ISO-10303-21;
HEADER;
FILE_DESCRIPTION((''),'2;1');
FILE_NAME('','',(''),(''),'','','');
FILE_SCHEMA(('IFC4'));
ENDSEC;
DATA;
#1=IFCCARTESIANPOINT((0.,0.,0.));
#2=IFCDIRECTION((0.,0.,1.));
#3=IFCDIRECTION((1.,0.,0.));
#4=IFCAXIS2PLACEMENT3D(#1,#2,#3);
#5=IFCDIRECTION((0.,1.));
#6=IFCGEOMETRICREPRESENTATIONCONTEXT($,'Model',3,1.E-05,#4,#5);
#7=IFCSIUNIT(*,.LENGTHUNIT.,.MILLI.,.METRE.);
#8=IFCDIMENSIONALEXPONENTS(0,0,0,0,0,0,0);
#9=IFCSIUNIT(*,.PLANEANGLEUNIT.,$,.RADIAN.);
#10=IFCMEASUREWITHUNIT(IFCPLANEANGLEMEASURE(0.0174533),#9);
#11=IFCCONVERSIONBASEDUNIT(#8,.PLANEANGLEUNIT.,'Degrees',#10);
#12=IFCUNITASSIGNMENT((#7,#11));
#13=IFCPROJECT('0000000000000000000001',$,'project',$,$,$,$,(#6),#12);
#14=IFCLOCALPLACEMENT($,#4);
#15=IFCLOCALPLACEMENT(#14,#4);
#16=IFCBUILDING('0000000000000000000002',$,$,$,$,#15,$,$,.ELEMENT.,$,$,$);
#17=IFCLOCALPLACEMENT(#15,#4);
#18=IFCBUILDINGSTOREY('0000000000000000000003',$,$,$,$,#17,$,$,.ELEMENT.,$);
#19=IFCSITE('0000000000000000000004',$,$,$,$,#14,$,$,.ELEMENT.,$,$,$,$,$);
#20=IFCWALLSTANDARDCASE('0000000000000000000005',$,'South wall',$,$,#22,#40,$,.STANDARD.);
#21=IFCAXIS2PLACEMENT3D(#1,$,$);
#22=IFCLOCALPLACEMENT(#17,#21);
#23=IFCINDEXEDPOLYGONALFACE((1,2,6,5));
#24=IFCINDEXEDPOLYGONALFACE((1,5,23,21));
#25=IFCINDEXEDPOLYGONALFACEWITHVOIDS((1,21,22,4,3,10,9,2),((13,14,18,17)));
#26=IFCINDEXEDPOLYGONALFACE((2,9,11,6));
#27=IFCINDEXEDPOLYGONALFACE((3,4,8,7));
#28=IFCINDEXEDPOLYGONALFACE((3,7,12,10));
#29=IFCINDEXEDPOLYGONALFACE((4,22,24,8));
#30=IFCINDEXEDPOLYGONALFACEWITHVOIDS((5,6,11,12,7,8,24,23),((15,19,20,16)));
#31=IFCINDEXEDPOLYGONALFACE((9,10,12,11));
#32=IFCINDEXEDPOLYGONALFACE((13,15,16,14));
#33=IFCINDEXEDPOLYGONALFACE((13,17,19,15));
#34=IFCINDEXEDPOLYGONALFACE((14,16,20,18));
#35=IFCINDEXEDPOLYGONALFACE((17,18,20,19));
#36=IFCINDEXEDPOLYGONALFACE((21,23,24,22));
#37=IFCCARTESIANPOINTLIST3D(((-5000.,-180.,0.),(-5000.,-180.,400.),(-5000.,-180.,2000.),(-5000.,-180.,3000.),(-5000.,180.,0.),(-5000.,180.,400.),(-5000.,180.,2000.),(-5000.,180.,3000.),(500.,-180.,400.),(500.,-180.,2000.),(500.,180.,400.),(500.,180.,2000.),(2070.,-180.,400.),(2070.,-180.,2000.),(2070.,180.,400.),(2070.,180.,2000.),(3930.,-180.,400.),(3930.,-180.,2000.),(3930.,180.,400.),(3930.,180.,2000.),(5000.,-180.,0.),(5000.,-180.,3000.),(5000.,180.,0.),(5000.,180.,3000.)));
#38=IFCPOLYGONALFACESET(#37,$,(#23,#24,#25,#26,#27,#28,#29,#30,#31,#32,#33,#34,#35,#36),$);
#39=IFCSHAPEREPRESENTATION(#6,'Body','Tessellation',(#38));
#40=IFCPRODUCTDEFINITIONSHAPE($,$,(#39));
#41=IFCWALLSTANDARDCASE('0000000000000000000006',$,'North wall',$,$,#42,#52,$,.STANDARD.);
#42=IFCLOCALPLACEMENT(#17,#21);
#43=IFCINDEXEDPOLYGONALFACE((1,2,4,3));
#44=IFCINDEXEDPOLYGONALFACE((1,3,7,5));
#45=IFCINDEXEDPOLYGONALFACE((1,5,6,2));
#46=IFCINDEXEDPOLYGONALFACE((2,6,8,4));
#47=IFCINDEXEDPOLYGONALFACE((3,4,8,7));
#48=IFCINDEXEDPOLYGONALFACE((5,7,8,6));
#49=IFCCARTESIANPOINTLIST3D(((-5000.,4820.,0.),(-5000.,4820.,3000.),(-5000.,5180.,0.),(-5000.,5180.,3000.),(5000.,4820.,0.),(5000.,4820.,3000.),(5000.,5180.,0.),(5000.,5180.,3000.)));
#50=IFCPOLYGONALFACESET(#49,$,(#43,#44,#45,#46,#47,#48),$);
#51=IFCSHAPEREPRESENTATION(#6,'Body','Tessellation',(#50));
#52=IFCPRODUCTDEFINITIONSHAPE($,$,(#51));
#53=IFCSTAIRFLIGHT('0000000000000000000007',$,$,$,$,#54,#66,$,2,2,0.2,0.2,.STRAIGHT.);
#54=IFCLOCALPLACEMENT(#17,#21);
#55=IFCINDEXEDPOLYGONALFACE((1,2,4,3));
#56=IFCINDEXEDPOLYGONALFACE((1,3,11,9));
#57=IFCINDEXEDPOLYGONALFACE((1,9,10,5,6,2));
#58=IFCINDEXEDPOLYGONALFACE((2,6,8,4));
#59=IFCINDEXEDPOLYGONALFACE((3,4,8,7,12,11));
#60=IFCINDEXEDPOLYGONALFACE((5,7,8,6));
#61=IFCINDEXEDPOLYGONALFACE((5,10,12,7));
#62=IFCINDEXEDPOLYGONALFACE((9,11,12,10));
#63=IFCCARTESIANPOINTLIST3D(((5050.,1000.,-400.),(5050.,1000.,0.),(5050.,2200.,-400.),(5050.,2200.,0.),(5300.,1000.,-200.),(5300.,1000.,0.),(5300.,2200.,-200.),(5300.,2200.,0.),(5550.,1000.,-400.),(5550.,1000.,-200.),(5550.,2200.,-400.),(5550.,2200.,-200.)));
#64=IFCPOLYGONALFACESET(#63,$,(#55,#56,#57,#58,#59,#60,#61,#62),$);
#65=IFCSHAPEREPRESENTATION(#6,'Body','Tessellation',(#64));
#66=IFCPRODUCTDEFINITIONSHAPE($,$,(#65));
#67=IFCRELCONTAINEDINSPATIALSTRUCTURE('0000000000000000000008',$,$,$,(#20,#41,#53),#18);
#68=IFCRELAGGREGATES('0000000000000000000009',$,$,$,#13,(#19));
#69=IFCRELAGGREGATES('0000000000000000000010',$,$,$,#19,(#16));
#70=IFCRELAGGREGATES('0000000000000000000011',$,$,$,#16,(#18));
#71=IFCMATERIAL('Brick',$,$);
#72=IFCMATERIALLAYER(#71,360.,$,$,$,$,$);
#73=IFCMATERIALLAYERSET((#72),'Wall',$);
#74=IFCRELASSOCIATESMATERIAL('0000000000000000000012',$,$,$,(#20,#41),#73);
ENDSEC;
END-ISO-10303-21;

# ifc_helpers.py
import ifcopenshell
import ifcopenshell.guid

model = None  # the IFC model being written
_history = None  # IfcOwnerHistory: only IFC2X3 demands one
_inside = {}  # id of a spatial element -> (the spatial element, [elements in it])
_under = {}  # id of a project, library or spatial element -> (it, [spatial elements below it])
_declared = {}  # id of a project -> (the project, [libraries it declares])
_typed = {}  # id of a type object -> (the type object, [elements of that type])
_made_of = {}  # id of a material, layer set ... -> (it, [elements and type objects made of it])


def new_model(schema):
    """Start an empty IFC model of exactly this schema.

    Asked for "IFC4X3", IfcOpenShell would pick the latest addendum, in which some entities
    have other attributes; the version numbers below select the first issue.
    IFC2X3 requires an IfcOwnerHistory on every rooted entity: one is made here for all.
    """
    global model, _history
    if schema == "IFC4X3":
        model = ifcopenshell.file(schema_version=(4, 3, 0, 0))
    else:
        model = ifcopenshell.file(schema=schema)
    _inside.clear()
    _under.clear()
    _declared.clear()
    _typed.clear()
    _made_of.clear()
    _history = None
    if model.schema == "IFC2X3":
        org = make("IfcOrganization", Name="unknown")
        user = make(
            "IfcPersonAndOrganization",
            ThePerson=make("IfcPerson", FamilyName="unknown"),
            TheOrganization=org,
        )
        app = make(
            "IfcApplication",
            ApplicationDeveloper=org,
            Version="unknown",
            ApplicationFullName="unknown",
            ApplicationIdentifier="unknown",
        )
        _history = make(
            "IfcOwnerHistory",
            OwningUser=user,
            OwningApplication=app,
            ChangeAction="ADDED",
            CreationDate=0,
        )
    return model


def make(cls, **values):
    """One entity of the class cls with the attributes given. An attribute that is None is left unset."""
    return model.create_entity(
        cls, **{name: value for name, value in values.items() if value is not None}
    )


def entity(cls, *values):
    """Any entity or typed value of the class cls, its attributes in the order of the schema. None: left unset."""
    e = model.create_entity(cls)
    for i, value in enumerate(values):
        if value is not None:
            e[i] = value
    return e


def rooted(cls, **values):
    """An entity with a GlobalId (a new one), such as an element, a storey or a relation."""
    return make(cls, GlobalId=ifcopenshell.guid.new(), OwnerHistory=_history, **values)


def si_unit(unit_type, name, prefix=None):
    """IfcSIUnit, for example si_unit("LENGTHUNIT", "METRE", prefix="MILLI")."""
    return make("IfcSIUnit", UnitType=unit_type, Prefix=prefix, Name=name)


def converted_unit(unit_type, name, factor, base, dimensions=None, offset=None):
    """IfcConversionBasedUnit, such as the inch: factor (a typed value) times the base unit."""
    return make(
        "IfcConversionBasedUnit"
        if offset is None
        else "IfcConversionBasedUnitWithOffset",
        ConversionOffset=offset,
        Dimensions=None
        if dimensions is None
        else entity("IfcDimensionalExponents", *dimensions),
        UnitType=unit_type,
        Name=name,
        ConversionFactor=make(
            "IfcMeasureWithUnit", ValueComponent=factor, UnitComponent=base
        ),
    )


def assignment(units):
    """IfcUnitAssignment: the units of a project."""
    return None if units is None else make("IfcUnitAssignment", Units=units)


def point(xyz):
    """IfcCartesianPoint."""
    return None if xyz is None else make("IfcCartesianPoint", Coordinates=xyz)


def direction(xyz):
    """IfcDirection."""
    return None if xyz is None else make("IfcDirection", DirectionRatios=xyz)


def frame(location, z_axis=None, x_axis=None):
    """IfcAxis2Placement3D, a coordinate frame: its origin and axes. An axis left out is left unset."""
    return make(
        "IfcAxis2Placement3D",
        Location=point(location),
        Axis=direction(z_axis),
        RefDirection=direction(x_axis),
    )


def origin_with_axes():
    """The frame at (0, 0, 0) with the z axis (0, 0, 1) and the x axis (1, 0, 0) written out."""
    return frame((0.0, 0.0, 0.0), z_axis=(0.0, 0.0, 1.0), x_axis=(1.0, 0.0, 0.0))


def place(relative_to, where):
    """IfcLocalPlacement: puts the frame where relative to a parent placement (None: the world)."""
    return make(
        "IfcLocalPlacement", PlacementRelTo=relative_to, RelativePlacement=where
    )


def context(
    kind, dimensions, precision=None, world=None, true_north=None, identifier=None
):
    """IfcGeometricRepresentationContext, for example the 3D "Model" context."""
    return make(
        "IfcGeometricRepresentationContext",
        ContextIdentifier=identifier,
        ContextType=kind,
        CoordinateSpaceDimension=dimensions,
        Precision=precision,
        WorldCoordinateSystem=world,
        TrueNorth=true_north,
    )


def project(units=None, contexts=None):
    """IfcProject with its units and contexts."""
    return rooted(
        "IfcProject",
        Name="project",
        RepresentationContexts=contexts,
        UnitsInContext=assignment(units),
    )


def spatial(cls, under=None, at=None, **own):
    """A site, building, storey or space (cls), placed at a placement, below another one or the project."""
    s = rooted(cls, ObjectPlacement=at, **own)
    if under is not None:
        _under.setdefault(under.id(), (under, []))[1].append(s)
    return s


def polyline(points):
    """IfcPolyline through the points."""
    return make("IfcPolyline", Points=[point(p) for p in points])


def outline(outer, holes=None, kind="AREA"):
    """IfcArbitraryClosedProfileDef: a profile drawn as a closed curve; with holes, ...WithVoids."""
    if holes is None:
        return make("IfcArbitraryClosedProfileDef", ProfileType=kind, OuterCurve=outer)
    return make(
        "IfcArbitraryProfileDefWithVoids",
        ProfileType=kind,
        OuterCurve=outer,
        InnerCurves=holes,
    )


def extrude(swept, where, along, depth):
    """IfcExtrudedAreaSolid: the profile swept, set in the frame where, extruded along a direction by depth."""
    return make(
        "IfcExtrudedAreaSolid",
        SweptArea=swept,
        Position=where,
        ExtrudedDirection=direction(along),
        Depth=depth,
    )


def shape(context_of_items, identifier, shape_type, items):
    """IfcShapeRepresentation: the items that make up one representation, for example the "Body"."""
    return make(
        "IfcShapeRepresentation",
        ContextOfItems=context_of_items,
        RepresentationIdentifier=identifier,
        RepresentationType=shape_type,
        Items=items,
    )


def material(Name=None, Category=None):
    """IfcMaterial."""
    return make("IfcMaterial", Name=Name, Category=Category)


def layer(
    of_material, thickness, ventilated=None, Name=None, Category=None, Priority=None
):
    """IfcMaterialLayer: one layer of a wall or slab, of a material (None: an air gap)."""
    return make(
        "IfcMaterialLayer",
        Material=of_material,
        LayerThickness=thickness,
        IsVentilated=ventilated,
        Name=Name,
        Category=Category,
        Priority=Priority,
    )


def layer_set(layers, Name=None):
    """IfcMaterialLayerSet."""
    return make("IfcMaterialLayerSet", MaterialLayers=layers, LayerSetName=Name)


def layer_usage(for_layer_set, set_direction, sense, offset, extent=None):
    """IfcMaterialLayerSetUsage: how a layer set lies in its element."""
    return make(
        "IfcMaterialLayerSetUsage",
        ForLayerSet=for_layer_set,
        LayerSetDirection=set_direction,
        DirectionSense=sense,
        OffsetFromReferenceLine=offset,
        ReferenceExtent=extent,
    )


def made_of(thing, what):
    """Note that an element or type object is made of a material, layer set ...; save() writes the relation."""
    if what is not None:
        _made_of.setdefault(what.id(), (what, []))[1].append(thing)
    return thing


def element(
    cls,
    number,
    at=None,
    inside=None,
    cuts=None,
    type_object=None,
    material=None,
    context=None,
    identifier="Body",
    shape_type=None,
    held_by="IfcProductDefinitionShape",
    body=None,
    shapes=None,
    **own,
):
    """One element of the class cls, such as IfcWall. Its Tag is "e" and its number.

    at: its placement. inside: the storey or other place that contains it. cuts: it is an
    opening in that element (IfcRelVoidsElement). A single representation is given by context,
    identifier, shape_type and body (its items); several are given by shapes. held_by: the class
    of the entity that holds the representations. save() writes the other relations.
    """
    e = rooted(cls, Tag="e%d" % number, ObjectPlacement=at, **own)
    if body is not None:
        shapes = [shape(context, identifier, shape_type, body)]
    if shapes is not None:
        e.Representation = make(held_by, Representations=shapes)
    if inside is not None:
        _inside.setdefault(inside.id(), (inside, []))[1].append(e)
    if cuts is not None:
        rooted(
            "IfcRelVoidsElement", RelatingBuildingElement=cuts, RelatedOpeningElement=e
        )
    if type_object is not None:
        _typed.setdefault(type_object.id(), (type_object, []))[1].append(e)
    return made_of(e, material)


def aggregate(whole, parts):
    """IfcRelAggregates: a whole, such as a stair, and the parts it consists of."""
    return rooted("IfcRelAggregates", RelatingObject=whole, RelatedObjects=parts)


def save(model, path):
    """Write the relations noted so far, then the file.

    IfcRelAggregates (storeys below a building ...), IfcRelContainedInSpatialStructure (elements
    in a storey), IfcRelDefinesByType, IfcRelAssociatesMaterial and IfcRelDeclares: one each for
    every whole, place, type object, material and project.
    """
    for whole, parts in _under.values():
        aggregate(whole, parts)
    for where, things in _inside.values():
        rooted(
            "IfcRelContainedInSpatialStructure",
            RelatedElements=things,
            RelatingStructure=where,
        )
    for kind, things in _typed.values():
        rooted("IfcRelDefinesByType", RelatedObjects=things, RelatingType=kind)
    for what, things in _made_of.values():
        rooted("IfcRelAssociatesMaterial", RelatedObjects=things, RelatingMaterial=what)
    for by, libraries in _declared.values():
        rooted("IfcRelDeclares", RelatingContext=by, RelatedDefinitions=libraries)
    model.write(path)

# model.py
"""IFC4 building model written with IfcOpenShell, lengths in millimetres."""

from ifc_helpers import new_model, entity, si_unit, converted_unit, direction, frame, origin_with_axes, place, context, project, spatial, polyline, outline, extrude, material, layer, layer_set, layer_usage, element, save


model = new_model("IFC4")

# Units and contexts
model_context = context("Model", 3, precision=1e-05, world=origin_with_axes(), true_north=direction((0.0, 1.0)))
ifc_project = project(units=[si_unit("LENGTHUNIT", "METRE", prefix="MILLI"), converted_unit("PLANEANGLEUNIT", "Degrees", entity("IfcPlaneAngleMeasure", 0.0174533), si_unit("PLANEANGLEUNIT", "RADIAN"), dimensions=[0, 0, 0, 0, 0, 0, 0])], contexts=[model_context])

# Site, building, storey
site_placement = place(None, origin_with_axes())
site = spatial("IfcSite", under=ifc_project, at=site_placement, CompositionType="ELEMENT")
building_placement = place(site_placement, origin_with_axes())
building = spatial("IfcBuilding", under=site, at=building_placement, CompositionType="ELEMENT")
storey_placement = place(building_placement, origin_with_axes())
storey = spatial("IfcBuildingStorey", under=building, at=storey_placement, CompositionType="ELEMENT")

# Shared definitions
ifc_material = material(Name="Brick")
ifc_layer = layer(ifc_material, 360.0)
ifc_layer_set = layer_set([ifc_layer], Name="Wall")
ifc_layer_usage = layer_usage(ifc_layer_set, "AXIS2", "POSITIVE", -180.0)

# Wall, openings
wall_1_placement = place(storey_placement, origin_with_axes())
wall_1 = element("IfcWallStandardCase", 1, at=wall_1_placement, inside=storey, material=ifc_layer_usage, Name="South wall", PredefinedType="STANDARD", context=model_context, shape_type="SweptSolid", body=[
    extrude(outline(polyline([(-5000.0, -180.0), (5000.0, -180.0), (5000.0, 180.0), (-5000.0, 180.0), (-5000.0, -180.0), (-5000.0, -180.0)])), origin_with_axes(), (0.0, 0.0, 1.0), 3000.0),
])
opening_1_placement = place(storey_placement, frame((3000.0, 0.0, 400.0), z_axis=(0.0, 0.0, 1.0), x_axis=(1.0, 0.0, 0.0)))
element("IfcOpeningElement", 2, at=opening_1_placement, cuts=wall_1, PredefinedType="OPENING", context=model_context, shape_type="SweptSolid", body=[
    extrude(outline(polyline([(-930.0, -1500.0), (930.0, -1500.0), (930.0, 1500.0), (-930.0, 1500.0), (-930.0, -1500.0), (-930.0, -1500.0)])), origin_with_axes(), (0.0, 0.0, 1.0), 1600.0),
])
opening_2_placement = place(wall_1_placement, frame((-2500.0, 0.0, 400.0), z_axis=(0.0, 0.0, 1.0), x_axis=(1.0, 0.0, 0.0)))
element("IfcOpeningElement", 3, at=opening_2_placement, cuts=wall_1, PredefinedType="OPENING", context=model_context, shape_type="SweptSolid", body=[
    extrude(outline(polyline([(-3000.0, -1815.0), (3000.0, -1815.0), (3000.0, 1815.0), (-3000.0, 1815.0), (-3000.0, -1815.0), (-3000.0, -1815.0)])), origin_with_axes(), (0.0, 0.0, 1.0), 1600.0),
])

# Wall
wall_2_placement = place(storey_placement, frame((0.0, 5000.0, 0.0), z_axis=(0.0, 0.0, 1.0), x_axis=(1.0, 0.0, 0.0)))
element("IfcWallStandardCase", 4, at=wall_2_placement, inside=storey, material=ifc_layer_usage, Name="North wall", PredefinedType="STANDARD", context=model_context, shape_type="SweptSolid", body=[
    extrude(outline(polyline([(-5000.0, -180.0), (5000.0, -180.0), (5000.0, 180.0), (-5000.0, 180.0), (-5000.0, -180.0), (-5000.0, -180.0)])), origin_with_axes(), (0.0, 0.0, 1.0), 3000.0),
])

# Stair flight
stair_flight_placement = place(storey_placement, frame((5050.0, 1000.0, 0.0), z_axis=(0.0, 1.0, 0.0), x_axis=(1.0, 0.0, 0.0)))
element("IfcStairFlight", 5, at=stair_flight_placement, inside=storey, NumberOfRisers=2, NumberOfTreads=2, PredefinedType="STRAIGHT", RiserHeight=0.2, TreadLength=0.2, context=model_context, shape_type="SweptSolid", body=[
    extrude(outline(polyline([(0.0, 0.0), (250.0, 0.0), (250.0, 200.0), (500.0, 200.0), (500.0, 400.0), (0.0, 400.0), (0.0, 0.0)])), origin_with_axes(), (0.0, 0.0, 1.0), 1200.0),
])

save(model, "model.ifc")
